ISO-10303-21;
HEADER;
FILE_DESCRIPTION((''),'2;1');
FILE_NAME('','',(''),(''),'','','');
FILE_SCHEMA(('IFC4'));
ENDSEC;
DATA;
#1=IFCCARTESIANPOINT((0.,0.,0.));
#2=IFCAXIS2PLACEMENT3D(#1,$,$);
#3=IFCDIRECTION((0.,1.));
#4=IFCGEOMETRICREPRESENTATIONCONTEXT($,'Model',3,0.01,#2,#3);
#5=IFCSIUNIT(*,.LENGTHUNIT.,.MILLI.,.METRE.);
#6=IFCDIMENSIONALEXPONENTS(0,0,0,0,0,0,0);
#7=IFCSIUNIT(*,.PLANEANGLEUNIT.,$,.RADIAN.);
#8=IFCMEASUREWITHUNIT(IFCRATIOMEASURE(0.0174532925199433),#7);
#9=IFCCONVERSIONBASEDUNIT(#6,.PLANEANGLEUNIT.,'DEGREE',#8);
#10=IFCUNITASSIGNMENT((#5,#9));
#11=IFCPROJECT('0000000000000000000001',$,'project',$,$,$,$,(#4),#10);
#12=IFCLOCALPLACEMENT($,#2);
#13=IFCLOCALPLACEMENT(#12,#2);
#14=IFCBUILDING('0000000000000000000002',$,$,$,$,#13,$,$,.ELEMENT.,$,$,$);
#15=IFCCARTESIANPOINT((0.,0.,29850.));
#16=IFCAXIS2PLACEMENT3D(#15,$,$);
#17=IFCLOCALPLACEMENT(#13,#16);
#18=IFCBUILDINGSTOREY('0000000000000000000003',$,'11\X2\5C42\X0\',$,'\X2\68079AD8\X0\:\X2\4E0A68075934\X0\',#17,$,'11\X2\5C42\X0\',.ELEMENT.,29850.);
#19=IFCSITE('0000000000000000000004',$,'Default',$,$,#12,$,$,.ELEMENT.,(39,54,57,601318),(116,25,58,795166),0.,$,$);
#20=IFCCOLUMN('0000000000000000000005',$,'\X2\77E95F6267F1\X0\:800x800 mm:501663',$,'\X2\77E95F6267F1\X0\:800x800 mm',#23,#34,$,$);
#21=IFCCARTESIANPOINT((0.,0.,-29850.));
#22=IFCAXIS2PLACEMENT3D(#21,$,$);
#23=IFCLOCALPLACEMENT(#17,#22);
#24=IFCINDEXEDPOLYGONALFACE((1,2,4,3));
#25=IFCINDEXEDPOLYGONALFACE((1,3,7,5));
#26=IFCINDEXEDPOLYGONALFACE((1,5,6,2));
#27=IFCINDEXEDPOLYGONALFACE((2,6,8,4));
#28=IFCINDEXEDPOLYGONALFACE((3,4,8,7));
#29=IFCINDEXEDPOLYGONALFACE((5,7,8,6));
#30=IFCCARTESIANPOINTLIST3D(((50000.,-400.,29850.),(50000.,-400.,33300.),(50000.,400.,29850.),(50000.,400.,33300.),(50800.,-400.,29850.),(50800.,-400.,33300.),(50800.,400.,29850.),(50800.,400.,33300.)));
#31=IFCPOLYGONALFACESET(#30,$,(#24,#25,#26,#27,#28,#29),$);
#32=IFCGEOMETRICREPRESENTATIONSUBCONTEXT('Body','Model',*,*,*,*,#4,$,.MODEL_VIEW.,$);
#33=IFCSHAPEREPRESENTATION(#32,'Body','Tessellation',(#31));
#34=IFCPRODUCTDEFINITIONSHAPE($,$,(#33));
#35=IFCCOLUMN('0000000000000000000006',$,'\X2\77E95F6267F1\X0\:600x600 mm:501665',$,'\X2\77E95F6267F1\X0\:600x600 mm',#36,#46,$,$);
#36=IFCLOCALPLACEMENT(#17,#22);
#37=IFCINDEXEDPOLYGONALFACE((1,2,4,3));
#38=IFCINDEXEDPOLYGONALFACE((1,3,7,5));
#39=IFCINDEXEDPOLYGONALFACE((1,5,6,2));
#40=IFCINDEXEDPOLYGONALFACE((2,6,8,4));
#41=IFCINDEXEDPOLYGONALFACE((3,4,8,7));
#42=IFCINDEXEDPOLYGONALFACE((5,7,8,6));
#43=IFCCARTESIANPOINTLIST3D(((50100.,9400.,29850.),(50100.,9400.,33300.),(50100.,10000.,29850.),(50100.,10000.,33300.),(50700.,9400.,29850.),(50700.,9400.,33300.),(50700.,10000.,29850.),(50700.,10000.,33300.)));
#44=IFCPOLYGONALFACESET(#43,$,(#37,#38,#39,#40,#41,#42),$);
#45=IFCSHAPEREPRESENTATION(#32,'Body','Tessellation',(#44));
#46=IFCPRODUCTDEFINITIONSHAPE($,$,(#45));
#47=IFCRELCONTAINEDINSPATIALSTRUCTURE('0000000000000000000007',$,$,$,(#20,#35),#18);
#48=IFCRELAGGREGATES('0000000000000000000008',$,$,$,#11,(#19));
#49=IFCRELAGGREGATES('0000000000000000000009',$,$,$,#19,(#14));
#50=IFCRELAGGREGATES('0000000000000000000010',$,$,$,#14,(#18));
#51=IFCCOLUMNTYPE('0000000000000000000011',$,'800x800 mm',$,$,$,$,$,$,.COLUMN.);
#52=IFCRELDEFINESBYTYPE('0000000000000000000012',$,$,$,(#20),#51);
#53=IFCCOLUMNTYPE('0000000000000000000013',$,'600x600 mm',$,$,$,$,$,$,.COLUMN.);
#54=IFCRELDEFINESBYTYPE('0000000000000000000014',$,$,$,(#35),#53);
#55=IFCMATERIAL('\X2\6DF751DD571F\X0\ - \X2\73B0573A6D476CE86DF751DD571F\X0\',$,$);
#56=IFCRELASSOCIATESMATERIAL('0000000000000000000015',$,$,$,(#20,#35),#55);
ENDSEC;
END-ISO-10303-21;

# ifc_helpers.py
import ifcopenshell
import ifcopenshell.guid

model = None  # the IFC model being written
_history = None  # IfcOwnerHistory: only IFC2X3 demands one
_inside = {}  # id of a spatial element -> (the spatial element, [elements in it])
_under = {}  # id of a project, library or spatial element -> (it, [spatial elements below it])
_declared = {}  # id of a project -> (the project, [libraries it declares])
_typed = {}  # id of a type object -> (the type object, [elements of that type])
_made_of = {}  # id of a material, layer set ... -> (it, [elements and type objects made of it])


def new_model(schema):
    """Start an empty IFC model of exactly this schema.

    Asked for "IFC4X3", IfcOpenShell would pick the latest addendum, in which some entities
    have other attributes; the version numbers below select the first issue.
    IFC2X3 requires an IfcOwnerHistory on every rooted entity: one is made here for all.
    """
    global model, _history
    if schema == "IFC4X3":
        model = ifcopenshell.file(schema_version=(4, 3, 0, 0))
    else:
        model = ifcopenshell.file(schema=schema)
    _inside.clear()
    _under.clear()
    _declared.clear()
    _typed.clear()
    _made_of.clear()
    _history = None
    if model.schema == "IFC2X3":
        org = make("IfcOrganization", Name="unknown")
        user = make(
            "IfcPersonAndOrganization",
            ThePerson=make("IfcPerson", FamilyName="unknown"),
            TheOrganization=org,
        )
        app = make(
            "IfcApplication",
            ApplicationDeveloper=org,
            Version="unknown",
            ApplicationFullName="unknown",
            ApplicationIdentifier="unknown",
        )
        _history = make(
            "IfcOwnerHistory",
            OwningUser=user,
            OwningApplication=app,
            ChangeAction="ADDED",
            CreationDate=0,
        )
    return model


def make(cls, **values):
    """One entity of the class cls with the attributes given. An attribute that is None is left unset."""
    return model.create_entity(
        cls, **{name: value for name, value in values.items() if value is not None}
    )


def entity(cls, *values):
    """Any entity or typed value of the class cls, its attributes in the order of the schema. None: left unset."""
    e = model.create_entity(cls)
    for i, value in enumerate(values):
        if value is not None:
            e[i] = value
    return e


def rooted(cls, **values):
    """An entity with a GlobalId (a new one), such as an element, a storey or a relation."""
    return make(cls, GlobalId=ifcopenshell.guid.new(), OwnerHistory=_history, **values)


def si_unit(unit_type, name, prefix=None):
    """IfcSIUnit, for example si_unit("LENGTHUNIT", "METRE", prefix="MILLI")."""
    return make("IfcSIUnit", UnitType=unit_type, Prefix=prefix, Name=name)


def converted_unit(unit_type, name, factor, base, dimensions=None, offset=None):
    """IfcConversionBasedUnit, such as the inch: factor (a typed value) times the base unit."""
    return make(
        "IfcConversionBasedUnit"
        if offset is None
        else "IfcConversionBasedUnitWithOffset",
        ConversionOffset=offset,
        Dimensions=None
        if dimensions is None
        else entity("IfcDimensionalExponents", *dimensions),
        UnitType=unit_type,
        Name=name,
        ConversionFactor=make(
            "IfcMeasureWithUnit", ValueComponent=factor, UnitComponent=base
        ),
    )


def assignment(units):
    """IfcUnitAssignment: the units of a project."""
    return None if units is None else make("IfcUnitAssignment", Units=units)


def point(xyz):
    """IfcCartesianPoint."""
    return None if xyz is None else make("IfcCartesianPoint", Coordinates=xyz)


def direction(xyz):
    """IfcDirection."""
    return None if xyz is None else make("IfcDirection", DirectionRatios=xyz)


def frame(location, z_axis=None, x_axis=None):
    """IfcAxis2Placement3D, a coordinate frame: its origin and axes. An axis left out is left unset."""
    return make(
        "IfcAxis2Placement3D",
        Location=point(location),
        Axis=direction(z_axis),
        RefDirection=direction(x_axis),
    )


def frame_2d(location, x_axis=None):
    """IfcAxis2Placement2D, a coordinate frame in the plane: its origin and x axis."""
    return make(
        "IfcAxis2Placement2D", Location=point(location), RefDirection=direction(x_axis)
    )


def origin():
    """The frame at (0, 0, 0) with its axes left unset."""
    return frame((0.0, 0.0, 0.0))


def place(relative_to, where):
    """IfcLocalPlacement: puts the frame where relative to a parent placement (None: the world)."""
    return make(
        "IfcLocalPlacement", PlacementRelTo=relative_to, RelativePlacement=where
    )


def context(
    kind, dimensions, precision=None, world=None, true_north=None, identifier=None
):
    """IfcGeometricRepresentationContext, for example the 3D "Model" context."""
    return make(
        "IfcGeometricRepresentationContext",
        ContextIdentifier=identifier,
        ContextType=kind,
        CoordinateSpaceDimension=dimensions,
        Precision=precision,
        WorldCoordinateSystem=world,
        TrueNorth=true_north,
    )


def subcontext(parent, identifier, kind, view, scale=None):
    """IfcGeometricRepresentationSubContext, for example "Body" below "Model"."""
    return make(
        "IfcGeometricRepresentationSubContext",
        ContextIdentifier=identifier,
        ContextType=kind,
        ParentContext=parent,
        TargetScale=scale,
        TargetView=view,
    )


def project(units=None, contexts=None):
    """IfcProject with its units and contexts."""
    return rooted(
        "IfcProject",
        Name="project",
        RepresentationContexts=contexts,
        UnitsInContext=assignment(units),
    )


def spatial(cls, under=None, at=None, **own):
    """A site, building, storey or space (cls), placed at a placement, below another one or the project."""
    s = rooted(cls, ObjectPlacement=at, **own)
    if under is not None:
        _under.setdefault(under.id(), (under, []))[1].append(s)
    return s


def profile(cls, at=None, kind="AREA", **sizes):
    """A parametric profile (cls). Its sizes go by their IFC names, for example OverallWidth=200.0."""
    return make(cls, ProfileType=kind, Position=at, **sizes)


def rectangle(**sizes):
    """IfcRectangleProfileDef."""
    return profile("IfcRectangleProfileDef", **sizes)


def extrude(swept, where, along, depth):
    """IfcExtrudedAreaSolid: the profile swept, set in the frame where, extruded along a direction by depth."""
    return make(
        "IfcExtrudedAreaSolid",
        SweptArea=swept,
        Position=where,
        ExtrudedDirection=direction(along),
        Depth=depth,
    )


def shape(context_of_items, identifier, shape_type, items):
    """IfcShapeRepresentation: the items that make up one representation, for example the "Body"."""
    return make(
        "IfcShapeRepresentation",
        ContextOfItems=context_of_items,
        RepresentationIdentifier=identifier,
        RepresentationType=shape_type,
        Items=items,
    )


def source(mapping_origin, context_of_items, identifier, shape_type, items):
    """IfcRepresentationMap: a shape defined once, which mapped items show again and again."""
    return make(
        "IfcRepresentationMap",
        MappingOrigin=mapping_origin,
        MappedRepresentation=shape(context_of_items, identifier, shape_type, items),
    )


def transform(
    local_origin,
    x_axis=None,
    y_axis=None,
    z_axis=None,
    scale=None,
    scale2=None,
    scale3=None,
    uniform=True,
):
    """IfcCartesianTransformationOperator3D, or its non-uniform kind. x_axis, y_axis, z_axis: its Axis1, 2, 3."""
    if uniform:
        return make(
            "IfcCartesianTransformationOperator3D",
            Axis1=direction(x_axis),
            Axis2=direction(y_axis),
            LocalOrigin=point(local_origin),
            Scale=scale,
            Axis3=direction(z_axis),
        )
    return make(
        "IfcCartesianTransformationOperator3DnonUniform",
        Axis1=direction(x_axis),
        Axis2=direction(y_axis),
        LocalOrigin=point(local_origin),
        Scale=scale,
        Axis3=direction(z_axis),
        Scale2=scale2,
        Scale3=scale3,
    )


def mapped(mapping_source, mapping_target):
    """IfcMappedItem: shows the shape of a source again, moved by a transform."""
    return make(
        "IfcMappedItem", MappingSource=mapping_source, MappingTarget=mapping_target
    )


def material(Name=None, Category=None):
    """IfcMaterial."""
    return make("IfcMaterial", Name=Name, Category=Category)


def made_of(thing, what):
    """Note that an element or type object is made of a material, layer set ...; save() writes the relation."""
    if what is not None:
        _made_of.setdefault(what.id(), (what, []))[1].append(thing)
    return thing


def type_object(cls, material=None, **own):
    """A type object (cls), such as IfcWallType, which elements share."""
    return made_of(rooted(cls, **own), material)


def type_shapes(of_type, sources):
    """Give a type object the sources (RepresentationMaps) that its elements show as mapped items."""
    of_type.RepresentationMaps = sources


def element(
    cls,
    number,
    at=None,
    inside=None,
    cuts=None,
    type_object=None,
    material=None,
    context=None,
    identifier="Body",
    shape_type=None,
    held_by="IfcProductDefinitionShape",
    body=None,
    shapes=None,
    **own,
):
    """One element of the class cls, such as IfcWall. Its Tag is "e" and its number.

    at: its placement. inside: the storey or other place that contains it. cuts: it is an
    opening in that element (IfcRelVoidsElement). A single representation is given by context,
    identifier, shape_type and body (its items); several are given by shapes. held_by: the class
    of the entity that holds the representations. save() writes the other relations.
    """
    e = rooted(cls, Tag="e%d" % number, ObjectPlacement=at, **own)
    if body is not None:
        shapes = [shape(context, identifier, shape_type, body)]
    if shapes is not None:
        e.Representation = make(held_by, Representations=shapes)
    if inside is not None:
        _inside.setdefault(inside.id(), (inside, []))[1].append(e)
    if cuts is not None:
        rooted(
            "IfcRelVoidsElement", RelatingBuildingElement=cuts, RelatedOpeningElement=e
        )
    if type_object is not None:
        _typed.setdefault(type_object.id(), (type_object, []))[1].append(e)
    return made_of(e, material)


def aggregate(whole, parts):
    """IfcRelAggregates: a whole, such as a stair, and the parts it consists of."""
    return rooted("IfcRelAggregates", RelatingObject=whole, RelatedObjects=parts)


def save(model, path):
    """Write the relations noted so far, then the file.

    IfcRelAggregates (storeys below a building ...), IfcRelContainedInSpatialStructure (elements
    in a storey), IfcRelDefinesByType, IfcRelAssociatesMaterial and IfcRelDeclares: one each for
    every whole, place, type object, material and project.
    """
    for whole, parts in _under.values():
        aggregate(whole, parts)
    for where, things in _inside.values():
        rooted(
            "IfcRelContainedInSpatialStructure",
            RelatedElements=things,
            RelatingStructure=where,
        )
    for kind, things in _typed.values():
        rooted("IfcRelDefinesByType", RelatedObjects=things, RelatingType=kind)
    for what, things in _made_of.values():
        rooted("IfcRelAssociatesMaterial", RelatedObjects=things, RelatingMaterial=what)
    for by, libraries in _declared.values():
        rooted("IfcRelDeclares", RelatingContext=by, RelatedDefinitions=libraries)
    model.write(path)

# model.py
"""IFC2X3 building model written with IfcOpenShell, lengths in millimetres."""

from ifc_helpers import new_model, entity, si_unit, converted_unit, direction, frame, frame_2d, origin, place, context, subcontext, project, spatial, rectangle, extrude, source, transform, mapped, material, type_object, type_shapes, element, save


model = new_model("IFC2X3")

# Units and contexts
model_context = context("Model", 3, precision=0.01, world=origin(), true_north=direction((0.0, 1.0)))
body_context = subcontext(model_context, "Body", "Model", "MODEL_VIEW")
ifc_project = project(units=[si_unit("LENGTHUNIT", "METRE", prefix="MILLI"), converted_unit("PLANEANGLEUNIT", "DEGREE", entity("IfcRatioMeasure", 0.0174532925199433), si_unit("PLANEANGLEUNIT", "RADIAN"), dimensions=[0, 0, 0, 0, 0, 0, 0])], contexts=[model_context])

# Site, building, storey
site_placement = place(None, origin())
site = spatial("IfcSite", under=ifc_project, at=site_placement, Name="Default", CompositionType="ELEMENT", RefLatitude=(39, 54, 57, 601318), RefLongitude=(116, 25, 58, 795166), RefElevation=0.0)
building_placement = place(site_placement, origin())
building = spatial("IfcBuilding", under=site, at=building_placement, CompositionType="ELEMENT")
storey_placement = place(building_placement, frame((0.0, 0.0, 29850.0)))
storey = spatial("IfcBuildingStorey", under=building, at=storey_placement, Name="11层", ObjectType="标高:上标头", LongName="11层", CompositionType="ELEMENT", Elevation=29850.0)

# Columns
ifc_material_1 = material(Name="混凝土 - 现场浇注混凝土")
column_type_1 = type_object("IfcColumnType", Name="800x800 mm", PredefinedType="COLUMN")
shared_shape_1 = source(origin(), body_context, "Body", "SweptSolid", [
    extrude(rectangle(XDim=800.0, YDim=800.0, at=frame_2d((0.0, 0.0), x_axis=(1.0, 0.0))), frame((50400.0, 0.0, 29850.0), z_axis=(0.0, 0.0, 1.0), x_axis=(0.0, -1.0, 0.0)), (0.0, 0.0, 1.0), 3450.0),
])
type_shapes(column_type_1, [shared_shape_1])
column_1_placement = place(storey_placement, frame((0.0, 0.0, -29850.0)))
element("IfcColumn", 1, at=column_1_placement, inside=storey, type_object=column_type_1, material=ifc_material_1, Name="矩形柱:800x800 mm:501663", ObjectType="矩形柱:800x800 mm", context=body_context, shape_type="MappedRepresentation", body=[
    mapped(shared_shape_1, transform((0.0, 0.0, 0.0), scale=1.0)),
])
column_type_2 = type_object("IfcColumnType", Name="600x600 mm", PredefinedType="COLUMN")
shared_shape_2 = source(origin(), body_context, "Body", "SweptSolid", [
    extrude(rectangle(XDim=600.0, YDim=600.0, at=frame_2d((0.0, 0.0), x_axis=(1.0, 0.0))), frame((50400.0, 9700.0, 29850.0), z_axis=(0.0, 0.0, 1.0), x_axis=(0.0, -1.0, 0.0)), (0.0, 0.0, 1.0), 3450.0),
])
type_shapes(column_type_2, [shared_shape_2])
column_2_placement = place(storey_placement, frame((0.0, 0.0, -29850.0)))
element("IfcColumn", 2, at=column_2_placement, inside=storey, type_object=column_type_2, material=ifc_material_1, Name="矩形柱:600x600 mm:501665", ObjectType="矩形柱:600x600 mm", context=body_context, shape_type="MappedRepresentation", body=[
    mapped(shared_shape_2, transform((0.0, 0.0, 0.0), scale=1.0)),
])

save(model, "model.ifc")
